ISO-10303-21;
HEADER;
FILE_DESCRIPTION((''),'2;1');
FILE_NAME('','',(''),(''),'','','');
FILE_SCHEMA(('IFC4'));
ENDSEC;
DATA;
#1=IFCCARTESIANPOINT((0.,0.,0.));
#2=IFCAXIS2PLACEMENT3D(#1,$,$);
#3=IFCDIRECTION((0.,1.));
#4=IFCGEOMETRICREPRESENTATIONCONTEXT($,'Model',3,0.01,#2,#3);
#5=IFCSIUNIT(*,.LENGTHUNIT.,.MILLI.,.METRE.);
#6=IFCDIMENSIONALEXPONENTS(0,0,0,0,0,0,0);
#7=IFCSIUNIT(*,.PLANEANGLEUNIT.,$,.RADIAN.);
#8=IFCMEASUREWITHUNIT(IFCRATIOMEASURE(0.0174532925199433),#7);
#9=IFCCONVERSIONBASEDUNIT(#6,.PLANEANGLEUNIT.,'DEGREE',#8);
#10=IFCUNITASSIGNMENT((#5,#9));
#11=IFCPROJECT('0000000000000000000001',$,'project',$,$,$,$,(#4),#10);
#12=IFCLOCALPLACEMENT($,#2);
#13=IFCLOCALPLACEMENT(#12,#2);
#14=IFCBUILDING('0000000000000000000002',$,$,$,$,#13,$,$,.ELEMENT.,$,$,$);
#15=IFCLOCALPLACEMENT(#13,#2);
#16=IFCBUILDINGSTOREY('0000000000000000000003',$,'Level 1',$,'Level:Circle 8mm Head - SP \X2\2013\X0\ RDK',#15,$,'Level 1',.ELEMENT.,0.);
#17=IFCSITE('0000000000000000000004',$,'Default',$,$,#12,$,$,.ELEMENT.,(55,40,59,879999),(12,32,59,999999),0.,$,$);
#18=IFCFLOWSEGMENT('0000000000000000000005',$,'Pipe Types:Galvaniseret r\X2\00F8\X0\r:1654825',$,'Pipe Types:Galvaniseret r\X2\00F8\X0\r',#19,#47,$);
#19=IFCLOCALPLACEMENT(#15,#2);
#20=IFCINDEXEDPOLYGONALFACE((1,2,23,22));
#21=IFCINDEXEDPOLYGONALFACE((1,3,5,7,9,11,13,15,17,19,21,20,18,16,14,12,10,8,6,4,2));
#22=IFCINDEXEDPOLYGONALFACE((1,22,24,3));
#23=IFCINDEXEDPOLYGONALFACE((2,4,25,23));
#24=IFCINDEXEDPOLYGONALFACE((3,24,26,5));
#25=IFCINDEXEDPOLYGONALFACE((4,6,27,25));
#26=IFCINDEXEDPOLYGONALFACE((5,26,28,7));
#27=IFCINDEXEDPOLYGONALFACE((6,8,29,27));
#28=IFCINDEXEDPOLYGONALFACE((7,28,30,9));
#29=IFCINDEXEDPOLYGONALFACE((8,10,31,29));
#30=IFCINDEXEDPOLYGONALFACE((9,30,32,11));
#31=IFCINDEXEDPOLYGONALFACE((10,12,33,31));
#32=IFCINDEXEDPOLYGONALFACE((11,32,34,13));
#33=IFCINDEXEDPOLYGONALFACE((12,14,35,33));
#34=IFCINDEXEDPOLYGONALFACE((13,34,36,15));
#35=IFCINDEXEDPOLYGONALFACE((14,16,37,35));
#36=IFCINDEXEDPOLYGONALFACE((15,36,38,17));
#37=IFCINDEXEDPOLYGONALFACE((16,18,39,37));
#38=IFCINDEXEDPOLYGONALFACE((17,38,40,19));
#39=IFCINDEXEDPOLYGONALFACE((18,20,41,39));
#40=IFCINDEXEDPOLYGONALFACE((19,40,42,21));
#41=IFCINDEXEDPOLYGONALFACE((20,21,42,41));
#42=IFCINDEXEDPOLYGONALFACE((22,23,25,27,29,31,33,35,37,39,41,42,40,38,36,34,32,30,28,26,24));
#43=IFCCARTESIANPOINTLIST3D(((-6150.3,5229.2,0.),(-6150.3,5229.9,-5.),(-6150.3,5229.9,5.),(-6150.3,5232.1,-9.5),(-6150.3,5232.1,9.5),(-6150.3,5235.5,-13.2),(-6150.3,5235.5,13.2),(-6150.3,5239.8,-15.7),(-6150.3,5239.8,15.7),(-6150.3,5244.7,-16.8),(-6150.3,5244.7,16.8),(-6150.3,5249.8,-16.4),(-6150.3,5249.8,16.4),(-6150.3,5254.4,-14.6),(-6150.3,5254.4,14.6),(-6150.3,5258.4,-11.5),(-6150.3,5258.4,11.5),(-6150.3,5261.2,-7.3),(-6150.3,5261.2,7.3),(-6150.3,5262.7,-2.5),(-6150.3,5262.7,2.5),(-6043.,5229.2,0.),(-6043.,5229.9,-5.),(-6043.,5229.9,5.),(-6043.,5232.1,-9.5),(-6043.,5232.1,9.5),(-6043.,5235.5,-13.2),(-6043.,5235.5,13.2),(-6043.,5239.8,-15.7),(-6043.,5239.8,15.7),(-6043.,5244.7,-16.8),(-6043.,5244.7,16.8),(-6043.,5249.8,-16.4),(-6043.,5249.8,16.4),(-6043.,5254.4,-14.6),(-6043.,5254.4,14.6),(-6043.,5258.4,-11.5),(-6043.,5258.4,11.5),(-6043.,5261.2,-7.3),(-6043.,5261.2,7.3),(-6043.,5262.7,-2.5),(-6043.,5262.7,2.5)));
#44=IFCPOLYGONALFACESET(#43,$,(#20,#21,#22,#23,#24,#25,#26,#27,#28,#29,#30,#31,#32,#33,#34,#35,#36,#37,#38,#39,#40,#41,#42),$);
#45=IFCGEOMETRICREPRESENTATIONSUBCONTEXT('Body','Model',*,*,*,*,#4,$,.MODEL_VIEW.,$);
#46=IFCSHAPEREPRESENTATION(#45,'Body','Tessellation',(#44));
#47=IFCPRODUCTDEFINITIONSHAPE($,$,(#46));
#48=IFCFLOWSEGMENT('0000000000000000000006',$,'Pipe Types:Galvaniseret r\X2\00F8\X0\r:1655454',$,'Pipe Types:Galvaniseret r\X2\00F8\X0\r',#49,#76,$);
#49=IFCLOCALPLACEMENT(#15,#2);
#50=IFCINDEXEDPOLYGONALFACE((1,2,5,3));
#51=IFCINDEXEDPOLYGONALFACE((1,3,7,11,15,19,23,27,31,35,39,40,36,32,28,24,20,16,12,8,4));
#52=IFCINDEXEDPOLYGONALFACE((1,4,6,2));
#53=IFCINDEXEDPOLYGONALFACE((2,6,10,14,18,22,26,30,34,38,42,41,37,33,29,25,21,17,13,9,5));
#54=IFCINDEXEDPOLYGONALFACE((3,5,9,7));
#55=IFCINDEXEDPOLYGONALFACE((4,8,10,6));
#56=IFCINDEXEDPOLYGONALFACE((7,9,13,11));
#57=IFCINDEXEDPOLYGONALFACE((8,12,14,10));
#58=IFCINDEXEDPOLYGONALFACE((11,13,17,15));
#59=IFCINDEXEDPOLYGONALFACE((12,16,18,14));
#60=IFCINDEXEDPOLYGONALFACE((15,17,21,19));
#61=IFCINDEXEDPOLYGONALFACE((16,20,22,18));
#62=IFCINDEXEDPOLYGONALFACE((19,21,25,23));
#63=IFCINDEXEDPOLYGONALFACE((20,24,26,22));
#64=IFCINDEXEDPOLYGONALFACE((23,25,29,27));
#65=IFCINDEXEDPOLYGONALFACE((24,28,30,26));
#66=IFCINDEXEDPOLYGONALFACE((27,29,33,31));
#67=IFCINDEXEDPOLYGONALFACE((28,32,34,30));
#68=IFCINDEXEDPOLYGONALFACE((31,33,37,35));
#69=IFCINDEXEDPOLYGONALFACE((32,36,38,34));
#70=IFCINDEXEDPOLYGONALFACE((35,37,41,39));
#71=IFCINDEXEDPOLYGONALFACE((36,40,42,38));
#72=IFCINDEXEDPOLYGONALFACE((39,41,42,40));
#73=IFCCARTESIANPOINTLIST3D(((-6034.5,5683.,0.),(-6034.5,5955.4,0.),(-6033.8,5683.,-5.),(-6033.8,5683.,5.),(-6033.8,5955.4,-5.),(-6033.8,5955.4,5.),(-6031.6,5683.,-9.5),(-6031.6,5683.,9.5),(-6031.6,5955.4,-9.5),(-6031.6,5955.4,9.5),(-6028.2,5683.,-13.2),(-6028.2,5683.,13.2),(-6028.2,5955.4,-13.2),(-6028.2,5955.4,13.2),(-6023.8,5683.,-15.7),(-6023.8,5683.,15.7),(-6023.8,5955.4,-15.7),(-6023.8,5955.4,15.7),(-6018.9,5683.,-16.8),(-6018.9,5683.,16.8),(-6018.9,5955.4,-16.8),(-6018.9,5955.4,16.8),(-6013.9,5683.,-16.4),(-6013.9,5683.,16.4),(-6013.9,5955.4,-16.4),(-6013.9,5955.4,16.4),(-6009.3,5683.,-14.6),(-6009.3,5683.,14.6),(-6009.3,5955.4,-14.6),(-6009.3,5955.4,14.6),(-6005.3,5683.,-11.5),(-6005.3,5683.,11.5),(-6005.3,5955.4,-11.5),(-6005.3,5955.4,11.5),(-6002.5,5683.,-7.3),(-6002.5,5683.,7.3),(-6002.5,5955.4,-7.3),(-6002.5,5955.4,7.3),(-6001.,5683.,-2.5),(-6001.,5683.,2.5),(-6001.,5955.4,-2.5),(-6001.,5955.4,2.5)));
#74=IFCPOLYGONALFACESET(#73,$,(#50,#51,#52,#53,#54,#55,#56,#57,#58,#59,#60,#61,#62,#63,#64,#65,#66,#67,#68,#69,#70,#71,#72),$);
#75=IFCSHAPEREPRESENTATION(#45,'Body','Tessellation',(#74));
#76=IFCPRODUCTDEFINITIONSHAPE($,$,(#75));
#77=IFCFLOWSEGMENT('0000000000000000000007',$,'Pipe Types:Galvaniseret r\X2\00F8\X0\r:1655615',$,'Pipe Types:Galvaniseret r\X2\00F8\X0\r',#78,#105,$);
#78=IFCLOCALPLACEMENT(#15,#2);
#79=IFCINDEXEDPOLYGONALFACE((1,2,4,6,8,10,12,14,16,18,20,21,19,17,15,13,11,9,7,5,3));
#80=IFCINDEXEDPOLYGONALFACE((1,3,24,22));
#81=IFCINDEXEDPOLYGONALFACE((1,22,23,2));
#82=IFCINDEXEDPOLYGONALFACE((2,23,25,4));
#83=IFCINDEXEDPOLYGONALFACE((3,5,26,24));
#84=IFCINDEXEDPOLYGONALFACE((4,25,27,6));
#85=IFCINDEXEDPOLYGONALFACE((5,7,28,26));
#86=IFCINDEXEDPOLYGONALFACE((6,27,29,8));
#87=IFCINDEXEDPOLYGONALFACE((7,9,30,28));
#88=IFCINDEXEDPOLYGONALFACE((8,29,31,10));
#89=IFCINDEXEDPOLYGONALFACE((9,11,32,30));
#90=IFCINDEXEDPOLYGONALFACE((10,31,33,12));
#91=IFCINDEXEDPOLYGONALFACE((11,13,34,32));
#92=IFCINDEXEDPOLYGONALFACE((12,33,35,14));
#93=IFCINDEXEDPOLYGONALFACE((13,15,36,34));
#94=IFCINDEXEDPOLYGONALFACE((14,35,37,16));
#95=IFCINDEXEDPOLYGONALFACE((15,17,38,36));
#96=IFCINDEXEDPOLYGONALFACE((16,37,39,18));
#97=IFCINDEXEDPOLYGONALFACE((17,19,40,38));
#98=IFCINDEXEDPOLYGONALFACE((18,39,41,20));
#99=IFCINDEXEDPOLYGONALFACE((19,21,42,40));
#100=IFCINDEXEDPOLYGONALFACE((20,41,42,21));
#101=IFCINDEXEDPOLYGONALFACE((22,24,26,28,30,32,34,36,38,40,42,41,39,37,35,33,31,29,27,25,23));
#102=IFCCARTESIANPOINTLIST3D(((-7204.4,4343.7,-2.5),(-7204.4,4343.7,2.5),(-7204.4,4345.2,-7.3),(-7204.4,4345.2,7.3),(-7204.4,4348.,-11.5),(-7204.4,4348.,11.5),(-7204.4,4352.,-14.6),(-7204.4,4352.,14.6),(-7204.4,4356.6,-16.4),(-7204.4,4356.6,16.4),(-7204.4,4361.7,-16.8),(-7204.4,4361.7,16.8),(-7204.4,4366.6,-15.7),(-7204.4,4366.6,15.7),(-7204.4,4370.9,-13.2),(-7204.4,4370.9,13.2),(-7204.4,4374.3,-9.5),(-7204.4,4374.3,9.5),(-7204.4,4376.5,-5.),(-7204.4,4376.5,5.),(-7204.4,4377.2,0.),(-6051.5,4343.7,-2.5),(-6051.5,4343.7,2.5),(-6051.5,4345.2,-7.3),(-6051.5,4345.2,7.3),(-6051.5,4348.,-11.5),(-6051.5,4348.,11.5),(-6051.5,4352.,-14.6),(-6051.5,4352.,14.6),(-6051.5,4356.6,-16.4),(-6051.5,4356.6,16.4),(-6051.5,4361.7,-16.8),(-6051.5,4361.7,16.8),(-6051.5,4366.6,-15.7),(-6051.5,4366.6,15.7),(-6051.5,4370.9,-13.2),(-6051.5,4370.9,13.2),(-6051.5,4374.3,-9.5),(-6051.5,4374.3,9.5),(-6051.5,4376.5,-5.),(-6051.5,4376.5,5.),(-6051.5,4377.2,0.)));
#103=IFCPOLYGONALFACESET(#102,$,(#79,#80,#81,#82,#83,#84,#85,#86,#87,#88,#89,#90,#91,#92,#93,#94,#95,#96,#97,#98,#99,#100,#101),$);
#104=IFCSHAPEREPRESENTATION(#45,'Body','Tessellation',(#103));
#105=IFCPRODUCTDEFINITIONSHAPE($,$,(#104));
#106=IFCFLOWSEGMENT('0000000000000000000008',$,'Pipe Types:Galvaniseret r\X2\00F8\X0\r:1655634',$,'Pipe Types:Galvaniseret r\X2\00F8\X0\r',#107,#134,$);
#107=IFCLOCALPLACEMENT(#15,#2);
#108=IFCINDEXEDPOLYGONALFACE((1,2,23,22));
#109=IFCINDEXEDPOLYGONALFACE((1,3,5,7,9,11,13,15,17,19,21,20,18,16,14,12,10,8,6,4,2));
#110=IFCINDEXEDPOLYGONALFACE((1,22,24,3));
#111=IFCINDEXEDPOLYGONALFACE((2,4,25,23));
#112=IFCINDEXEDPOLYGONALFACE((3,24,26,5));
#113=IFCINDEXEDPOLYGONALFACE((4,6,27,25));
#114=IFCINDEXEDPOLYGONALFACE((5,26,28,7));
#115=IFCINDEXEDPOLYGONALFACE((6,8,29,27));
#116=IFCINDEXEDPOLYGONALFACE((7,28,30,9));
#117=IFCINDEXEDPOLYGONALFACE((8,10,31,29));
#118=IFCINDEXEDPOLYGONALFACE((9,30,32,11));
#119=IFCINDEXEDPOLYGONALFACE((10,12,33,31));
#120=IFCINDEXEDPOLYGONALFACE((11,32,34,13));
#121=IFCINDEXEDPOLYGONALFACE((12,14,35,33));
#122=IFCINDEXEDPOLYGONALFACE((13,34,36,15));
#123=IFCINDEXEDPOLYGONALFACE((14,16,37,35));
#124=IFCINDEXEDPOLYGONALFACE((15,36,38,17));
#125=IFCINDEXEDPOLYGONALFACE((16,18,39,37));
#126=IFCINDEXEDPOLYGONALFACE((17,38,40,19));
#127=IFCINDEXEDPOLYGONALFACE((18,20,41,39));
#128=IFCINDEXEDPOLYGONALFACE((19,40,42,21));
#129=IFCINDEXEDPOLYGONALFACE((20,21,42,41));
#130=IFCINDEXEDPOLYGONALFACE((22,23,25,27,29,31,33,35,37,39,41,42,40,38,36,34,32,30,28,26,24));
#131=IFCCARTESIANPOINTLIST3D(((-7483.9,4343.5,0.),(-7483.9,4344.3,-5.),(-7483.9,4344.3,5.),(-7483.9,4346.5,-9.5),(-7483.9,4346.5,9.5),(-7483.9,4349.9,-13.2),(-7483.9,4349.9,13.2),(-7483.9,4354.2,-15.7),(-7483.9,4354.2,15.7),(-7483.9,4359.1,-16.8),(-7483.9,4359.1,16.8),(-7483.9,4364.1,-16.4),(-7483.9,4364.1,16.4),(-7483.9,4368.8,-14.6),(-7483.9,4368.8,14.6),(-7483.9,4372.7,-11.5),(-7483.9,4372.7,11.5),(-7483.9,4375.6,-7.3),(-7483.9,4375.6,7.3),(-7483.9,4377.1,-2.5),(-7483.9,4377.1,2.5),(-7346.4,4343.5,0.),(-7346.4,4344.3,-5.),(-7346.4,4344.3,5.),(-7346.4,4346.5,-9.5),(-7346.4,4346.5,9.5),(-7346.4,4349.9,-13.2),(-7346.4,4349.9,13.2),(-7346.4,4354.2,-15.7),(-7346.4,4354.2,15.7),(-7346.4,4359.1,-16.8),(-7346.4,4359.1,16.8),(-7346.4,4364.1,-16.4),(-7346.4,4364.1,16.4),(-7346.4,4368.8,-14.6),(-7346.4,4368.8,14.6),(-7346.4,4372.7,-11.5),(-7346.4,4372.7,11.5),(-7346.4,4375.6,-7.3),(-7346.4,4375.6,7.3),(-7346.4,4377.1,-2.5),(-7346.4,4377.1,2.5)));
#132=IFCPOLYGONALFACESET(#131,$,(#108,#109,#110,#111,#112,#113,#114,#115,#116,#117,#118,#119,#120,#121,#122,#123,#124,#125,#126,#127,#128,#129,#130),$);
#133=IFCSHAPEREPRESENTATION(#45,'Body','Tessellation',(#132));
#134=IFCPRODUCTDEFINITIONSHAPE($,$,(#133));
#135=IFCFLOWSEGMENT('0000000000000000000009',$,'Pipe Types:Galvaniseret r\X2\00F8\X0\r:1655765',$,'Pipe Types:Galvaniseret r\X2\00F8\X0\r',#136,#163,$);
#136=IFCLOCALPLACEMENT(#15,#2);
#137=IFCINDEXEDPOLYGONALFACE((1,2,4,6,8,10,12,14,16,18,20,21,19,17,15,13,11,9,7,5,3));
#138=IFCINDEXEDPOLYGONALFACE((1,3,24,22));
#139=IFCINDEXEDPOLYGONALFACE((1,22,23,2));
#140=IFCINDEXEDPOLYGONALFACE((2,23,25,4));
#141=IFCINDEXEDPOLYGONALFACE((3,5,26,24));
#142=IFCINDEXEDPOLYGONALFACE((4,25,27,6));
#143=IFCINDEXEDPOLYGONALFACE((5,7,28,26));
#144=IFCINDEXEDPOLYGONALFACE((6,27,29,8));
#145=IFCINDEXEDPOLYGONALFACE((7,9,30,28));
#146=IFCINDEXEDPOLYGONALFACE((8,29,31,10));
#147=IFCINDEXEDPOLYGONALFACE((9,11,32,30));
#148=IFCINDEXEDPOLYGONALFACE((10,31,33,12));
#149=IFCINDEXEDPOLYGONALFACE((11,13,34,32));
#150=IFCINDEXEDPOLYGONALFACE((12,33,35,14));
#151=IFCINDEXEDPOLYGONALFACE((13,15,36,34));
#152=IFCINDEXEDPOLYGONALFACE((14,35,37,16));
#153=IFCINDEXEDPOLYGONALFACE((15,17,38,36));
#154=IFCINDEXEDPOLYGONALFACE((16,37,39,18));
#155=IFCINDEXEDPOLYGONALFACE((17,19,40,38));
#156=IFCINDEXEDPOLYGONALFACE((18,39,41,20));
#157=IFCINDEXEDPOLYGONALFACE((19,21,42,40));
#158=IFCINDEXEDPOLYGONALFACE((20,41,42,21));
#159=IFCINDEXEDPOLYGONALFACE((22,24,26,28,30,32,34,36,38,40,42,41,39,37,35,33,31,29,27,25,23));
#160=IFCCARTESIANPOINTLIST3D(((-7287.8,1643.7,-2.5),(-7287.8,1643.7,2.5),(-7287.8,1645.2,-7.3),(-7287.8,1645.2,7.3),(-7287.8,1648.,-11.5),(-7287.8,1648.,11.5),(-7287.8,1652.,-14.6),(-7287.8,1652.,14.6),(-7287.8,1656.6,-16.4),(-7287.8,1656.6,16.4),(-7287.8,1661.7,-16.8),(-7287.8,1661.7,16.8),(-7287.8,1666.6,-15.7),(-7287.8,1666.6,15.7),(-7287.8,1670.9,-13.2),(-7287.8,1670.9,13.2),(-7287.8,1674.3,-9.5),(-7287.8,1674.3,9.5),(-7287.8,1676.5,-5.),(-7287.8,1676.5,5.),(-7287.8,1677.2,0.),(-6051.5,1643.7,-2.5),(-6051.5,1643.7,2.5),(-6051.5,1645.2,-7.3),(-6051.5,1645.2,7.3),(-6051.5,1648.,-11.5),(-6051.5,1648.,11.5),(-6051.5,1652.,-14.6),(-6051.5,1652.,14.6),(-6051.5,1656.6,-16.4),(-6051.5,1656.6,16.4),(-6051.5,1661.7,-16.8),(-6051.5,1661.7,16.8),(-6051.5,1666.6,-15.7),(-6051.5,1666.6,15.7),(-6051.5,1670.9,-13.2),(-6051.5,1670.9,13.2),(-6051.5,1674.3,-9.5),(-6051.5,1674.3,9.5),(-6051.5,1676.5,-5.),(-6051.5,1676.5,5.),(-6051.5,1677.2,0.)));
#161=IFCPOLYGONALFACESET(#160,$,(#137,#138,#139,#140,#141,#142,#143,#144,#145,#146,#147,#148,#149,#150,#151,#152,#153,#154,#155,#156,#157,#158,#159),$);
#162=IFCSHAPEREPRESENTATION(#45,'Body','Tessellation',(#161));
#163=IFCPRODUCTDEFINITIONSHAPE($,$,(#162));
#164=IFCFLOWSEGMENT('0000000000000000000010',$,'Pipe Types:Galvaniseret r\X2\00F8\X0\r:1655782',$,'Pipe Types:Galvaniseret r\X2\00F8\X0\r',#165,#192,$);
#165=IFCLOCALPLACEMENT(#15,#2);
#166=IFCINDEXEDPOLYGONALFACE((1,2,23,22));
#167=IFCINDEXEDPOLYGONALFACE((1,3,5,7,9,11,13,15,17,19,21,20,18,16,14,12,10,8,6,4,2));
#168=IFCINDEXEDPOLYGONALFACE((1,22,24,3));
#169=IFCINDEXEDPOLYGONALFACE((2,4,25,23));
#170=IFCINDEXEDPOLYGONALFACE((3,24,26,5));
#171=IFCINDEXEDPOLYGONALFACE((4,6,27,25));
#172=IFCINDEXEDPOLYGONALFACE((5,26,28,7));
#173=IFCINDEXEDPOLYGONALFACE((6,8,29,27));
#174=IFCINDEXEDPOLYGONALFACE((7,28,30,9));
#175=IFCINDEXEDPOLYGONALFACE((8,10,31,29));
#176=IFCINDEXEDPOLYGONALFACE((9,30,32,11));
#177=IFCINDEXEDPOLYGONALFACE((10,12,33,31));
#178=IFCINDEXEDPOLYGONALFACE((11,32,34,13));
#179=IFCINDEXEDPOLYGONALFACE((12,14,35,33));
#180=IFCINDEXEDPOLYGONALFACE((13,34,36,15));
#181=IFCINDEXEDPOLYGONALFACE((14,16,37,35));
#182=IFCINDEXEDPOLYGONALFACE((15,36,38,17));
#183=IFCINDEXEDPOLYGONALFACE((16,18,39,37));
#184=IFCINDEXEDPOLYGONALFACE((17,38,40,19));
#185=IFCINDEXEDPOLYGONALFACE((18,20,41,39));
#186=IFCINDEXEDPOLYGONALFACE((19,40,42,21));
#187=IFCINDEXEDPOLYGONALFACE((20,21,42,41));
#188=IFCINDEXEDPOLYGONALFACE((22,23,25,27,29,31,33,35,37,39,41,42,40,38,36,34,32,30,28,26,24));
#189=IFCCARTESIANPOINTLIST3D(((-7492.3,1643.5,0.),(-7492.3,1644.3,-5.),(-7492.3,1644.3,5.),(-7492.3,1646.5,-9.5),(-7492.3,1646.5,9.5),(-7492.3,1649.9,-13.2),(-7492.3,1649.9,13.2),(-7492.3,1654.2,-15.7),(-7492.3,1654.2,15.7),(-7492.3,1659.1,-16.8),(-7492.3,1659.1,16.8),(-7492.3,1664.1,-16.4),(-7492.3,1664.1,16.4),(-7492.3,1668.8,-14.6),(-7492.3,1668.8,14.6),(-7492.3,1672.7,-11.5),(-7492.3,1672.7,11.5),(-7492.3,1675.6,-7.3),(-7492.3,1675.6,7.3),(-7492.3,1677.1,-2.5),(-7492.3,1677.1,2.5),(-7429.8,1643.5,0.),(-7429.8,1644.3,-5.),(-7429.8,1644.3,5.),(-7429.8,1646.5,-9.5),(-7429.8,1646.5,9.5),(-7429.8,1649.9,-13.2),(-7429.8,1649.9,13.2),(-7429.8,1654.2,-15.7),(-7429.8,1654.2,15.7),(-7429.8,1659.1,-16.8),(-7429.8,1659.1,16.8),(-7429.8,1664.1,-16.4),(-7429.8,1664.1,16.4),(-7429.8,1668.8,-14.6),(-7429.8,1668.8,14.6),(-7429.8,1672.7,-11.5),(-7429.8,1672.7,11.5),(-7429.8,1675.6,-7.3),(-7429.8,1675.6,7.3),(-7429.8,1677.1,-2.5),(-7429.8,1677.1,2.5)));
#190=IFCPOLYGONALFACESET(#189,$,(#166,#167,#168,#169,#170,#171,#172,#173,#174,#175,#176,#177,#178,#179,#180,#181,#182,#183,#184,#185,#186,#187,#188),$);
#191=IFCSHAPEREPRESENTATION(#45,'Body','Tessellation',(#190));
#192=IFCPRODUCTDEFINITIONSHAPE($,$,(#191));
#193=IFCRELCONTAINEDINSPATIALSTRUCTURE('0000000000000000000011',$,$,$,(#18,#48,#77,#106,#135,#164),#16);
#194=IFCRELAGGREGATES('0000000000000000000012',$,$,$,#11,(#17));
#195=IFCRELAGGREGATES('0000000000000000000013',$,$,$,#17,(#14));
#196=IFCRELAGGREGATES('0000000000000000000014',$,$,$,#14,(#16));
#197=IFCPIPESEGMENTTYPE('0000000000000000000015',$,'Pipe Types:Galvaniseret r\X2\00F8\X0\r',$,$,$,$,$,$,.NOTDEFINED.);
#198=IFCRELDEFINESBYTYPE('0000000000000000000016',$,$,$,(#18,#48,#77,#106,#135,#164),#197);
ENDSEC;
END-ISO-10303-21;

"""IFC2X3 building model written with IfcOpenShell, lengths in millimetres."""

from ifc_helpers import new_model, entity, si_unit, converted_unit, direction, frame, frame_2d, origin, place, context, subcontext, project, spatial, circle, extrude, type_object, element, save


model = new_model("IFC2X3")

# Units and contexts
model_context = context("Model", 3, precision=0.01, world=origin(), true_north=direction((0.0, 1.0)))
body_context = subcontext(model_context, "Body", "Model", "MODEL_VIEW")
ifc_project = project(units=[si_unit("LENGTHUNIT", "METRE", prefix="MILLI"), converted_unit("PLANEANGLEUNIT", "DEGREE", entity("IfcRatioMeasure", 0.0174532925199433), si_unit("PLANEANGLEUNIT", "RADIAN"), dimensions=[0, 0, 0, 0, 0, 0, 0])], contexts=[model_context])

# Site, building, storey
site_placement = place(None, origin())
site = spatial("IfcSite", under=ifc_project, at=site_placement, Name="Default", CompositionType="ELEMENT", RefLatitude=(55, 40, 59, 879999), RefLongitude=(12, 32, 59, 999999), RefElevation=0.0)
building_placement = place(site_placement, origin())
building = spatial("IfcBuilding", under=site, at=building_placement, CompositionType="ELEMENT")
storey_placement = place(building_placement, origin())
storey = spatial("IfcBuildingStorey", under=building, at=storey_placement, Name="Level 1", ObjectType="Level:Circle 8mm Head - SP – RDK", LongName="Level 1", CompositionType="ELEMENT", Elevation=0.0)

# Flow segments
pipe_segment_type = type_object("IfcPipeSegmentType", Name="Pipe Types:Galvaniseret rør", PredefinedType="NOTDEFINED")
flow_segment_1_placement = place(storey_placement, origin())
element("IfcFlowSegment", 1, at=flow_segment_1_placement, inside=storey, type_object=pipe_segment_type, Name="Pipe Types:Galvaniseret rør:1654825", ObjectType="Pipe Types:Galvaniseret rør", context=body_context, shape_type="SweptSolid", body=[
    extrude(circle(Radius=16.9, at=frame_2d((0.0, 0.0), x_axis=(1.0, 0.0))), frame((-6150.3, 5246.0, 0.0), z_axis=(1.0, 0.0, 0.0), x_axis=(0.0, -1.0, 0.0)), (0.0, 0.0, 1.0), 107.2),
])
flow_segment_2_placement = place(storey_placement, origin())
element("IfcFlowSegment", 2, at=flow_segment_2_placement, inside=storey, type_object=pipe_segment_type, Name="Pipe Types:Galvaniseret rør:1655454", ObjectType="Pipe Types:Galvaniseret rør", context=body_context, shape_type="SweptSolid", body=[
    extrude(circle(Radius=16.9, at=frame_2d((0.0, 0.0), x_axis=(1.0, 0.0))), frame((-6017.7, 5683.0, 0.0), z_axis=(0.0, 1.0, 0.0), x_axis=(-1.0, 0.0, 0.0)), (0.0, 0.0, 1.0), 272.4),
])
flow_segment_3_placement = place(storey_placement, origin())
element("IfcFlowSegment", 3, at=flow_segment_3_placement, inside=storey, type_object=pipe_segment_type, Name="Pipe Types:Galvaniseret rør:1655615", ObjectType="Pipe Types:Galvaniseret rør", context=body_context, shape_type="SweptSolid", body=[
    extrude(circle(Radius=16.9, at=frame_2d((0.0, 0.0), x_axis=(1.0, 0.0))), frame((-7204.4, 4360.4, 0.0), z_axis=(1.0, 0.0, 0.0), x_axis=(0.0, 1.0, 0.0)), (0.0, 0.0, 1.0), 1152.9),
])
flow_segment_4_placement = place(storey_placement, origin())
element("IfcFlowSegment", 4, at=flow_segment_4_placement, inside=storey, type_object=pipe_segment_type, Name="Pipe Types:Galvaniseret rør:1655634", ObjectType="Pipe Types:Galvaniseret rør", context=body_context, shape_type="SweptSolid", body=[
    extrude(circle(Radius=16.9, at=frame_2d((0.0, 0.0), x_axis=(1.0, 0.0))), frame((-7483.9, 4360.4, 0.0), z_axis=(1.0, 0.0, 0.0), x_axis=(0.0, -1.0, 0.0)), (0.0, 0.0, 1.0), 137.5),
])
flow_segment_5_placement = place(storey_placement, origin())
element("IfcFlowSegment", 5, at=flow_segment_5_placement, inside=storey, type_object=pipe_segment_type, Name="Pipe Types:Galvaniseret rør:1655765", ObjectType="Pipe Types:Galvaniseret rør", context=body_context, shape_type="SweptSolid", body=[
    extrude(circle(Radius=16.9, at=frame_2d((0.0, 0.0), x_axis=(1.0, 0.0))), frame((-7287.8, 1660.4, 0.0), z_axis=(1.0, 0.0, 0.0), x_axis=(0.0, 1.0, 0.0)), (0.0, 0.0, 1.0), 1236.3),
])
flow_segment_6_placement = place(storey_placement, origin())
element("IfcFlowSegment", 6, at=flow_segment_6_placement, inside=storey, type_object=pipe_segment_type, Name="Pipe Types:Galvaniseret rør:1655782", ObjectType="Pipe Types:Galvaniseret rør", context=body_context, shape_type="SweptSolid", body=[
    extrude(circle(Radius=16.9, at=frame_2d((0.0, 0.0), x_axis=(1.0, 0.0))), frame((-7492.3, 1660.4, 0.0), z_axis=(1.0, 0.0, 0.0), x_axis=(0.0, -1.0, 0.0)), (0.0, 0.0, 1.0), 62.6),
])

save(model, "model.ifc")
